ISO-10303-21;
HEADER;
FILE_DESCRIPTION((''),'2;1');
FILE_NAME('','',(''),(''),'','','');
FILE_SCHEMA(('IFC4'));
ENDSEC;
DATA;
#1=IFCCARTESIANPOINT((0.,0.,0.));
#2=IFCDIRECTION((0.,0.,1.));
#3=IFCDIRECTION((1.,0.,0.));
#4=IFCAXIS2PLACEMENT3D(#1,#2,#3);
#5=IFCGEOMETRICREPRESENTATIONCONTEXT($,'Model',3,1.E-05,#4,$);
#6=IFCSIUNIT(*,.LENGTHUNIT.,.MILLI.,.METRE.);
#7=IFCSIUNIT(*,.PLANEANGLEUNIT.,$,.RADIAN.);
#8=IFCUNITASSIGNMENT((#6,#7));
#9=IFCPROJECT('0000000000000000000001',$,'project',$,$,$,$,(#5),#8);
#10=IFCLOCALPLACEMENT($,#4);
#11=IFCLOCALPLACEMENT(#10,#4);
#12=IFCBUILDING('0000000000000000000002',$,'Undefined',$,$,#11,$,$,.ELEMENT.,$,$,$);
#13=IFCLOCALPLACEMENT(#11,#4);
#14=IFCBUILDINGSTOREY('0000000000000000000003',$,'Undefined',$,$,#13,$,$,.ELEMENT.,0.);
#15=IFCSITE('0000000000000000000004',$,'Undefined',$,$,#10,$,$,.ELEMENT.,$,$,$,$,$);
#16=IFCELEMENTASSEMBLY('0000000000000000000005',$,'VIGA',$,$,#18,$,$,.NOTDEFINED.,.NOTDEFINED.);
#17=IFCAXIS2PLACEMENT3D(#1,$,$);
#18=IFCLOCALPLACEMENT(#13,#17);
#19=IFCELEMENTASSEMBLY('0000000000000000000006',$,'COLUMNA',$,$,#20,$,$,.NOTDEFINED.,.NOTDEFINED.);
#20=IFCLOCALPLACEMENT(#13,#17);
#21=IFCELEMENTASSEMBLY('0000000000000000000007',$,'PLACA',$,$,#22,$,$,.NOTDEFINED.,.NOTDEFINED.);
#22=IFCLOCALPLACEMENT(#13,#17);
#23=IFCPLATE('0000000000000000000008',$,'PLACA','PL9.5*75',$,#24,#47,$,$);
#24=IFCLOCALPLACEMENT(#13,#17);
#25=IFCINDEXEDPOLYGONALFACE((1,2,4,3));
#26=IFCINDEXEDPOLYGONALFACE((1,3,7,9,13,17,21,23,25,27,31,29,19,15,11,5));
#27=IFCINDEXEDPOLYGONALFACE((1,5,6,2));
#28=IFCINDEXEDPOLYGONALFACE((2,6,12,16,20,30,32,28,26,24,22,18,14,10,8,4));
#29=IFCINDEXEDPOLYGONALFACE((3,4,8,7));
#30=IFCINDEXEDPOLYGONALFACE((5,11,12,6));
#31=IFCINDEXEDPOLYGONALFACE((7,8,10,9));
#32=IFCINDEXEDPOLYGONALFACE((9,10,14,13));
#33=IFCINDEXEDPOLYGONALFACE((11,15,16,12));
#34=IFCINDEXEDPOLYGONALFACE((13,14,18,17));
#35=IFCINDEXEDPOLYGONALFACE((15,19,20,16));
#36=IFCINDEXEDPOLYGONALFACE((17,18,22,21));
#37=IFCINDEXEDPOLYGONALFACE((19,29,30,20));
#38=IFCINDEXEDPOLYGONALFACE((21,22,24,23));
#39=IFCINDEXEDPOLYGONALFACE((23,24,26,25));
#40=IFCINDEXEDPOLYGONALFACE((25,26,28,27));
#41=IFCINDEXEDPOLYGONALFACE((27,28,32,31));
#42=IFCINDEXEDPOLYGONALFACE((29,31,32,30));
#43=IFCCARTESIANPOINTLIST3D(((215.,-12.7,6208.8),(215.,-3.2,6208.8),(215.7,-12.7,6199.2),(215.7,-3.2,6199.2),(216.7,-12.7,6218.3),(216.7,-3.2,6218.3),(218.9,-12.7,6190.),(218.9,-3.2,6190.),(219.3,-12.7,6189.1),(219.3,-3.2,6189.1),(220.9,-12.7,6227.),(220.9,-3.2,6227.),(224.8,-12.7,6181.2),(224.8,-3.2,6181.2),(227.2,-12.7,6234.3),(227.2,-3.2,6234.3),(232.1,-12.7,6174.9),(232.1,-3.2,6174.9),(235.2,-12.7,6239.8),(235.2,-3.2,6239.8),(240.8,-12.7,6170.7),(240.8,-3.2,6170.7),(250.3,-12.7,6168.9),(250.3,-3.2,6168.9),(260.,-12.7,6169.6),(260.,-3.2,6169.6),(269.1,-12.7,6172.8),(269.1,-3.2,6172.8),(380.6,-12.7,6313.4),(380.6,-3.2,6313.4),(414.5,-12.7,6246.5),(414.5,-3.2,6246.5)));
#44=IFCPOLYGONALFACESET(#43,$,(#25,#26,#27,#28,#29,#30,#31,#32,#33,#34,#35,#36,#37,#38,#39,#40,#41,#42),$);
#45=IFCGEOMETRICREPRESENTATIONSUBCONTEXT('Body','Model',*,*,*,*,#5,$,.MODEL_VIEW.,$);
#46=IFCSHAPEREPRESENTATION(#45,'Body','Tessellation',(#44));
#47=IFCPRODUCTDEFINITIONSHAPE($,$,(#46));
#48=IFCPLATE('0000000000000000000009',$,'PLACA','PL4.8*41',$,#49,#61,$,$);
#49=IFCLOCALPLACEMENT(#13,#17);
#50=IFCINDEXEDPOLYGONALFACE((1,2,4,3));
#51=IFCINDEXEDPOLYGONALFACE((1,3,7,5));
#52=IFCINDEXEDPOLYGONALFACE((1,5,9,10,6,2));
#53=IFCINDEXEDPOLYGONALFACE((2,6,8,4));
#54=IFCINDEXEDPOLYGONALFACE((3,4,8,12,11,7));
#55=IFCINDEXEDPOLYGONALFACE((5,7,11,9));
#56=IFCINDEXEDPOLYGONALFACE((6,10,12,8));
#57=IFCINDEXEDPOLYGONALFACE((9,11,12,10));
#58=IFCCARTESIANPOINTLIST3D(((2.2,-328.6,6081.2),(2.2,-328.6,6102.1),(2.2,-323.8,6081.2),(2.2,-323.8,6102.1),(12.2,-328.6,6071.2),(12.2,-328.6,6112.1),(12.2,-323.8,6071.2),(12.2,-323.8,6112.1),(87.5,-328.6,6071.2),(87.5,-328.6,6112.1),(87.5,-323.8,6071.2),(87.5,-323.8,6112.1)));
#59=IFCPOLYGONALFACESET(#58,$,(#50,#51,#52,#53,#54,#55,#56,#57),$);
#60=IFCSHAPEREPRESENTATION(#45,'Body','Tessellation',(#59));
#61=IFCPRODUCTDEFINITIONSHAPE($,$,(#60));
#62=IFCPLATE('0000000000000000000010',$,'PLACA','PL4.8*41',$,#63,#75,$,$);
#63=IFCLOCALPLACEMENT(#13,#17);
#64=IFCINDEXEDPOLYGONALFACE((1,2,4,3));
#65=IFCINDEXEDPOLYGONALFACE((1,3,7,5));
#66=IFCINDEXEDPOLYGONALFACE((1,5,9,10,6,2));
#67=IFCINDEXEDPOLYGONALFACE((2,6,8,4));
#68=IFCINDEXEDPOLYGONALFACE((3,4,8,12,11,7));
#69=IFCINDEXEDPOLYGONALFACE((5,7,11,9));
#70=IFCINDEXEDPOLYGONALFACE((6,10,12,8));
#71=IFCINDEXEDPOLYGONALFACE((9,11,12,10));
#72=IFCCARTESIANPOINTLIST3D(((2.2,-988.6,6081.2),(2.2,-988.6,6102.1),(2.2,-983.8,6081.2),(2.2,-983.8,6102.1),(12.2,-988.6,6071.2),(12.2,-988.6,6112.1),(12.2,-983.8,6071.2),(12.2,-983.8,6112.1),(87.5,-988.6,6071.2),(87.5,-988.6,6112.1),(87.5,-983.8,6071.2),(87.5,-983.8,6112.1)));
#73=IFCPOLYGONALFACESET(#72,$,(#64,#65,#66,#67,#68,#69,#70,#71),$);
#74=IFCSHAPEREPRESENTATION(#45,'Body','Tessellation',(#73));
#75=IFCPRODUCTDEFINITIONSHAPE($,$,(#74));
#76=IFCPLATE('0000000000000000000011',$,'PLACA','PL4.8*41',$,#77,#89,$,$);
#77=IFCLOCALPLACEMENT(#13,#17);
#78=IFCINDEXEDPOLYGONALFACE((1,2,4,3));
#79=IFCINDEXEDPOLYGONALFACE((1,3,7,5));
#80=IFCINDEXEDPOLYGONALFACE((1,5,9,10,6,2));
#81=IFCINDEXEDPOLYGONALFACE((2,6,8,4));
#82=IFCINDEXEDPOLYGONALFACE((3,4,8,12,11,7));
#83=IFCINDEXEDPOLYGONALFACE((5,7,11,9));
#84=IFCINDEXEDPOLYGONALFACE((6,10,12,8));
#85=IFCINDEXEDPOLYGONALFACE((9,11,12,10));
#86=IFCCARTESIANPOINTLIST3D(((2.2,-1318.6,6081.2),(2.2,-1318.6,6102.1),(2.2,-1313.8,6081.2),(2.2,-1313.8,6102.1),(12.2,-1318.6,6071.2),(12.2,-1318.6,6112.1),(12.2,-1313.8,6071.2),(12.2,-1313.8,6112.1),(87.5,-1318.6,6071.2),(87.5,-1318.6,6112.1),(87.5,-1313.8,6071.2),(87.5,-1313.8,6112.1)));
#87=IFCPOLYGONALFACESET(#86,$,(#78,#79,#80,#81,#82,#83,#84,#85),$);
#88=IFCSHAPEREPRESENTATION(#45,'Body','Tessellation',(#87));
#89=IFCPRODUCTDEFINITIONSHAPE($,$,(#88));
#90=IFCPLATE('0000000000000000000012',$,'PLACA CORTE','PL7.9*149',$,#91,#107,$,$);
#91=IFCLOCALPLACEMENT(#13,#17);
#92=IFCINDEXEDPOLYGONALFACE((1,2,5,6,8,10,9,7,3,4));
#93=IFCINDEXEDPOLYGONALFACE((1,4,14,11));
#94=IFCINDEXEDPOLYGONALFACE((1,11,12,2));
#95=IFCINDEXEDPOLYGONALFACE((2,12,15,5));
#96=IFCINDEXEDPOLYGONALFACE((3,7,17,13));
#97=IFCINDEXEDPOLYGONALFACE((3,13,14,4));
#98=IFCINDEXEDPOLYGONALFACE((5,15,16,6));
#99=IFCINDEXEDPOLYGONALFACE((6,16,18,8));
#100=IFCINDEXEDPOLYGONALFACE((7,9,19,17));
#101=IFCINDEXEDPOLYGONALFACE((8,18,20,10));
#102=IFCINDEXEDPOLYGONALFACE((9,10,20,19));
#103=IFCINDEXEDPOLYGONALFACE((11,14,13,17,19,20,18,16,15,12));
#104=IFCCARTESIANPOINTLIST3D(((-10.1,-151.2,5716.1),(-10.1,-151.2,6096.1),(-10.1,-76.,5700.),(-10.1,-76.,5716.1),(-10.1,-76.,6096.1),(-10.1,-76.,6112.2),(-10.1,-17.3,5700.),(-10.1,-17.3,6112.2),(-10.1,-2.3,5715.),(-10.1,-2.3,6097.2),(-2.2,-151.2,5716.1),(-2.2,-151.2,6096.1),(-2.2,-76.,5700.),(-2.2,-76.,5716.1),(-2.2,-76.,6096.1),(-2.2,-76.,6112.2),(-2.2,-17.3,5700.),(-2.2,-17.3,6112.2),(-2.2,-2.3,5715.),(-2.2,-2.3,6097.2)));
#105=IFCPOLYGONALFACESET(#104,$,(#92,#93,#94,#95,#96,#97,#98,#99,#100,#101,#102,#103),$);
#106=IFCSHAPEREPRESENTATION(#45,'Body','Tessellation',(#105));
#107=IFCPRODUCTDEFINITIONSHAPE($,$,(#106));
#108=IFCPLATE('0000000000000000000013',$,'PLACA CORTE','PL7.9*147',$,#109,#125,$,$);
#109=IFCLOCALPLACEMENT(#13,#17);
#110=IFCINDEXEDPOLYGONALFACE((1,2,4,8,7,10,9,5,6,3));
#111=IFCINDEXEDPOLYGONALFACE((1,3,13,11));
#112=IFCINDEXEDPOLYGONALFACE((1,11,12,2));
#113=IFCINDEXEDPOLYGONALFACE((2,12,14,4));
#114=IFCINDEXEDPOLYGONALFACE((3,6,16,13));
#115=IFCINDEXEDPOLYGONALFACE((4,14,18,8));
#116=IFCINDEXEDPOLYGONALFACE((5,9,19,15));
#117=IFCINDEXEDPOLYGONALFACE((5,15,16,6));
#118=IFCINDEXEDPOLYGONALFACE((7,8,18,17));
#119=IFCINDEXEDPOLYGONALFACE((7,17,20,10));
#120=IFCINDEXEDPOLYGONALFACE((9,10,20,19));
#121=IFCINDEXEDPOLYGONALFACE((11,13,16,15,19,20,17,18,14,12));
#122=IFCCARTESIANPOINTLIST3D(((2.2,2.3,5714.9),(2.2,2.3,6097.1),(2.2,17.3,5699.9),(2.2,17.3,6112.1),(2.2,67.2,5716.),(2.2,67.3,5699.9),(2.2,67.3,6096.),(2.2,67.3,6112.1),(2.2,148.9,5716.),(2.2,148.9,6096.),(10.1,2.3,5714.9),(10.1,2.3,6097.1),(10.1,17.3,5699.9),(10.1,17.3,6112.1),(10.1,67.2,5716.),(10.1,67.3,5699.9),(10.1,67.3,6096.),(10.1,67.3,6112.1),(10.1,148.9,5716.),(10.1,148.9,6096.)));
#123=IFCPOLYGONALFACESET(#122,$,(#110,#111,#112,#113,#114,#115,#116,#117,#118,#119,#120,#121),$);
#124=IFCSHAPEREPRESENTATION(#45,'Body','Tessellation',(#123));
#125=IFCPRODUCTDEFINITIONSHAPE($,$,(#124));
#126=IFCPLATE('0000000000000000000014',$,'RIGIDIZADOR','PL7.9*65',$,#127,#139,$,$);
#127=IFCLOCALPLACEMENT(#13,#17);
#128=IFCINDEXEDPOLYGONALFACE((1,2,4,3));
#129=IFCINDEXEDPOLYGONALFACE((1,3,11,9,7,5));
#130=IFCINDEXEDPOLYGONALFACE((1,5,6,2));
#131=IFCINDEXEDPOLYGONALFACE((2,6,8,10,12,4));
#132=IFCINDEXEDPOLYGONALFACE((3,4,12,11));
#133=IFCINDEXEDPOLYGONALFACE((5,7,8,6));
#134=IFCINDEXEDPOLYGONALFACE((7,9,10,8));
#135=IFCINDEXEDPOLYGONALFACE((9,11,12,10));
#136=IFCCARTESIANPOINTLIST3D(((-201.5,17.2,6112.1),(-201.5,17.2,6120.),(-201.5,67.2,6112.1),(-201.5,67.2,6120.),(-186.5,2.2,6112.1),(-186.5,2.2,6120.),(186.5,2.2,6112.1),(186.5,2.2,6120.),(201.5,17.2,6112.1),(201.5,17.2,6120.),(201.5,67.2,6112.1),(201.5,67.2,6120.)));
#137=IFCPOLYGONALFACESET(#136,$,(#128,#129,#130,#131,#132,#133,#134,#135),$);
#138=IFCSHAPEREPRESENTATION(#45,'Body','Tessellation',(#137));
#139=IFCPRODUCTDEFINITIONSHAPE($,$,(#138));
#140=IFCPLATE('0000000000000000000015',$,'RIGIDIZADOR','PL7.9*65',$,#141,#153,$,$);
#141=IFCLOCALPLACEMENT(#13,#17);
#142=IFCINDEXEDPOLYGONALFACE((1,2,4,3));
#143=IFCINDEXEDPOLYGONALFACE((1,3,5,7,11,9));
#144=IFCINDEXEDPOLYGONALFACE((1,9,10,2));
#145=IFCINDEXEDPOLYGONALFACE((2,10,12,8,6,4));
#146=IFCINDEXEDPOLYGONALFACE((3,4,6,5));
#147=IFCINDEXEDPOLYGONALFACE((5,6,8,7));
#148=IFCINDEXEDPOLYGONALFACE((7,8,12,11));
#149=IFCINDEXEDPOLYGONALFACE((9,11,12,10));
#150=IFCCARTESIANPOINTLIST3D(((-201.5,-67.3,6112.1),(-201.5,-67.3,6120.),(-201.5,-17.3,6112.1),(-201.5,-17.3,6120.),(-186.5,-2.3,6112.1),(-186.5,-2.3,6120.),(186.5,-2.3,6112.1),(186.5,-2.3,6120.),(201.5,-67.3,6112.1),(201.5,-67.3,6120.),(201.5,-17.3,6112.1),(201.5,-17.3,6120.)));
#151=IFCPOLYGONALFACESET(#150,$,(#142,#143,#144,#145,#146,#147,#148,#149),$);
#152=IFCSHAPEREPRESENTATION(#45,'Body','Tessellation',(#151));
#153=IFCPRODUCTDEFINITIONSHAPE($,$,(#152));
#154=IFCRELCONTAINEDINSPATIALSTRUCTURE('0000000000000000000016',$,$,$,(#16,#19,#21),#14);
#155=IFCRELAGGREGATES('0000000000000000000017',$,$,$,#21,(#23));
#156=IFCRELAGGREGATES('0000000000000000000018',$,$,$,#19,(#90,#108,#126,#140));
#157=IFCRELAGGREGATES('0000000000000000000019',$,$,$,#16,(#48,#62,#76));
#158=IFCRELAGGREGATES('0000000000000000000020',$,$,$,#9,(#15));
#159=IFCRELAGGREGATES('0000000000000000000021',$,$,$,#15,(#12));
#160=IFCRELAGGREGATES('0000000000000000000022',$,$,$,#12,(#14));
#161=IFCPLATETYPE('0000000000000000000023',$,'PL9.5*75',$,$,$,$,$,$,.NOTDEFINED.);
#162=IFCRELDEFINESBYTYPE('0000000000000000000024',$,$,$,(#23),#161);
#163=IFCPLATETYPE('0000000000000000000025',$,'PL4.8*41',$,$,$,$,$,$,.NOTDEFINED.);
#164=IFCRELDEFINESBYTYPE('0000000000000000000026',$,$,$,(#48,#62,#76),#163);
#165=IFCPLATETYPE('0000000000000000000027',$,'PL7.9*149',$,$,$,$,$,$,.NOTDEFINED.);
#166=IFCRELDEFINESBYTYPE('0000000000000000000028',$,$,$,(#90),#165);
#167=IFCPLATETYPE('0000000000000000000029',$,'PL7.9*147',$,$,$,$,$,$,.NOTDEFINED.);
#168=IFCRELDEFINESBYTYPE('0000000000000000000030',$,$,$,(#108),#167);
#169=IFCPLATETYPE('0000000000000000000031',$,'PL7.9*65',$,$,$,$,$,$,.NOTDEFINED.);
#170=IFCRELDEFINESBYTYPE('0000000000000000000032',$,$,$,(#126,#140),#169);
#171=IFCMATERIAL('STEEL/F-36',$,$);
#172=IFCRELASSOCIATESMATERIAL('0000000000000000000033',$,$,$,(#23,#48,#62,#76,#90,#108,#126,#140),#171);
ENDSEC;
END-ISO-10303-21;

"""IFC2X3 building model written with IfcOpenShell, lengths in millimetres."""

from ifc_helpers import new_model, si_unit, frame, frame_2d, origin_with_axes, place, context, subcontext, project, spatial, polyline, circle_curve, parameter, trimmed, segment, composite_curve, outline, extrude, material, type_object, element, aggregate, save


model = new_model("IFC2X3")

# Units and contexts
model_context = context("Model", 3, precision=1e-05, world=origin_with_axes())
body_context = subcontext(model_context, "Body", "Model", "MODEL_VIEW")
ifc_project = project(units=[si_unit("LENGTHUNIT", "METRE", prefix="MILLI"), si_unit("PLANEANGLEUNIT", "RADIAN")], contexts=[model_context])

# Site, building, storey
site_placement = place(None, origin_with_axes())
site = spatial("IfcSite", under=ifc_project, at=site_placement, Name="Undefined", CompositionType="ELEMENT")
building_placement = place(site_placement, origin_with_axes())
building = spatial("IfcBuilding", under=site, at=building_placement, Name="Undefined", CompositionType="ELEMENT")
storey_placement = place(building_placement, origin_with_axes())
storey = spatial("IfcBuildingStorey", under=building, at=storey_placement, Name="Undefined", CompositionType="ELEMENT", Elevation=0.0)

# Element assembly
assembly_1_placement = place(storey_placement, origin_with_axes())
assembly_1 = element("IfcElementAssembly", 1, at=assembly_1_placement, inside=storey, Name="VIGA", AssemblyPlace="NOTDEFINED", PredefinedType="NOTDEFINED")
ifc_material_1 = material(Name="STEEL/F-36")

# Element assembly
assembly_2_placement = place(storey_placement, origin_with_axes())
assembly_2 = element("IfcElementAssembly", 2, at=assembly_2_placement, inside=storey, Name="COLUMNA", AssemblyPlace="NOTDEFINED", PredefinedType="NOTDEFINED")

# Element assembly, plate
assembly_3_placement = place(storey_placement, origin_with_axes())
assembly_3 = element("IfcElementAssembly", 3, at=assembly_3_placement, inside=storey, Name="PLACA", AssemblyPlace="NOTDEFINED", PredefinedType="NOTDEFINED")
plate_type_1 = type_object("IfcPlateType", Name="PL9.5*75", PredefinedType="NOTDEFINED")
plate_1_placement = place(assembly_3_placement, frame((202.2, -7.9, 6223.0), z_axis=(0.0, -1.0, 0.0), x_axis=(0.451662, 0.0, -0.892189)))
plate_1 = element("IfcPlate", 4, at=plate_1_placement, type_object=plate_type_1, material=ifc_material_1, Name="PLACA", Description="PL9.5*75", context=body_context, shape_type="SweptSolid", body=[
    extrude(outline(composite_curve([segment(trimmed(circle_curve(frame_2d((37.0, 37.0), x_axis=(-1.0, 0.0)), 37.0), [parameter(0.0)], [parameter(1.570796)], True, "PARAMETER"), True, "CONTINUOUS"), segment(polyline([(37.0, 0.0), (38.0, 0.0)]), True, "CONTINUOUS"), segment(trimmed(circle_curve(frame_2d((38.0, 37.0), x_axis=(0.0, -1.0)), 37.0), [parameter(0.0)], [parameter(1.570797)], True, "PARAMETER"), True, "CONTINUOUS"), segment(polyline([(75.0, 37.0), (75.0, 200.0), (0.0, 200.0), (0.0, 37.0)]), True, "CONTINUOUS")], self_intersect=True)), frame((0.0, 0.0, -4.8), z_axis=(0.0, 0.0, 1.0), x_axis=(1.0, 0.0, 0.0)), (0.0, 0.0, 1.0), 9.5),
])
aggregate(assembly_3, [plate_1])

# Plates
plate_type_2 = type_object("IfcPlateType", Name="PL4.8*41", PredefinedType="NOTDEFINED")
plate_2_placement = place(assembly_1_placement, frame((2.2, -326.2, 6112.1), z_axis=(0.0, 1.0, 0.0), x_axis=(1.0, 0.0, -0.000007)))
plate_2 = element("IfcPlate", 5, at=plate_2_placement, type_object=plate_type_2, material=ifc_material_1, Name="PLACA", Description="PL4.8*41", context=body_context, shape_type="SweptSolid", body=[
    extrude(outline(polyline([(0.0, 10.0), (10.0, 0.0), (85.2, 0.0), (85.3, 40.9), (10.0, 40.9), (0.0, 30.9), (0.0, 10.0)])), frame((0.0, 0.0, -2.4), z_axis=(0.0, 0.0, 1.0), x_axis=(1.0, 0.0, 0.0)), (0.0, 0.0, 1.0), 4.8),
])
plate_3_placement = place(assembly_1_placement, frame((2.2, -986.2, 6112.1), z_axis=(0.0, 1.0, 0.0), x_axis=(1.0, 0.0, -0.000007)))
plate_3 = element("IfcPlate", 6, at=plate_3_placement, type_object=plate_type_2, material=ifc_material_1, Name="PLACA", Description="PL4.8*41", context=body_context, shape_type="SweptSolid", body=[
    extrude(outline(polyline([(0.0, 10.0), (10.0, 0.0), (85.2, 0.0), (85.3, 40.9), (10.0, 40.9), (0.0, 30.9), (0.0, 10.0)])), frame((0.0, 0.0, -2.4), z_axis=(0.0, 0.0, 1.0), x_axis=(1.0, 0.0, 0.0)), (0.0, 0.0, 1.0), 4.8),
])
plate_4_placement = place(assembly_1_placement, frame((2.2, -1316.2, 6112.1), z_axis=(0.0, 1.0, 0.0), x_axis=(1.0, 0.0, -0.000007)))
plate_4 = element("IfcPlate", 7, at=plate_4_placement, type_object=plate_type_2, material=ifc_material_1, Name="PLACA", Description="PL4.8*41", context=body_context, shape_type="SweptSolid", body=[
    extrude(outline(polyline([(0.0, 10.0), (10.0, 0.0), (85.2, 0.0), (85.3, 40.9), (10.0, 40.9), (0.0, 30.9), (0.0, 10.0)])), frame((0.0, 0.0, -2.4), z_axis=(0.0, 0.0, 1.0), x_axis=(1.0, 0.0, 0.0)), (0.0, 0.0, 1.0), 4.8),
])
plate_type_3 = type_object("IfcPlateType", Name="PL7.9*149", PredefinedType="NOTDEFINED")
plate_5_placement = place(assembly_2_placement, frame((-6.2, -2.3, 6112.2), z_axis=(1.0, 0.0, 0.0), x_axis=(0.0, -1.0, 0.0)))
plate_5 = element("IfcPlate", 8, at=plate_5_placement, type_object=plate_type_3, material=ifc_material_1, Name="PLACA CORTE", Description="PL7.9*149", context=body_context, shape_type="SweptSolid", body=[
    extrude(outline(polyline([(0.0, 15.0), (15.0, 0.0), (73.8, 0.0), (73.7, 16.1), (148.9, 16.1), (148.9, 396.1), (73.7, 396.1), (73.7, 412.2), (15.0, 412.2), (0.0, 397.2), (0.0, 15.0)])), frame((0.0, 0.0, -4.0), z_axis=(0.0, 0.0, 1.0), x_axis=(1.0, 0.0, 0.0)), (0.0, 0.0, 1.0), 7.9),
])
plate_type_4 = type_object("IfcPlateType", Name="PL7.9*147", PredefinedType="NOTDEFINED")
plate_6_placement = place(assembly_2_placement, frame((6.2, 2.3, 6112.1), z_axis=(-1.0, 0.0, 0.0), x_axis=(0.0, 1.0, 0.0)))
plate_6 = element("IfcPlate", 9, at=plate_6_placement, type_object=plate_type_4, material=ifc_material_1, Name="PLACA CORTE", Description="PL7.9*147", context=body_context, shape_type="SweptSolid", body=[
    extrude(outline(polyline([(0.0, 15.0), (15.0, 0.0), (65.0, 0.0), (65.0, 16.1), (146.6, 16.1), (146.6, 396.1), (65.0, 396.1), (65.0, 412.2), (15.0, 412.2), (0.0, 397.2), (0.0, 15.0)])), frame((0.0, 0.0, -4.0), z_axis=(0.0, 0.0, 1.0), x_axis=(1.0, 0.0, 0.0)), (0.0, 0.0, 1.0), 7.9),
])
plate_type_5 = type_object("IfcPlateType", Name="PL7.9*65", PredefinedType="NOTDEFINED")
plate_7_placement = place(assembly_2_placement, frame((201.5, 2.2, 6116.0), z_axis=(0.0, 0.0, 1.0), x_axis=(0.000001, 1.0, 0.0)))
plate_7 = element("IfcPlate", 10, at=plate_7_placement, type_object=plate_type_5, material=ifc_material_1, Name="RIGIDIZADOR", Description="PL7.9*65", context=body_context, shape_type="SweptSolid", body=[
    extrude(outline(polyline([(0.0, 15.0), (15.0, 0.0), (65.0, 0.0), (65.0, 403.0), (15.0, 403.0), (0.0, 388.0), (0.0, 15.0)])), frame((0.0, 0.0, -4.0), z_axis=(0.0, 0.0, 1.0), x_axis=(1.0, 0.0, 0.0)), (0.0, 0.0, 1.0), 7.9),
])
plate_8_placement = place(assembly_2_placement, frame((201.5, -2.3, 6116.0), z_axis=(0.0, 0.0, -1.0), x_axis=(-0.000001, -1.0, 0.0)))
plate_8 = element("IfcPlate", 11, at=plate_8_placement, type_object=plate_type_5, material=ifc_material_1, Name="RIGIDIZADOR", Description="PL7.9*65", context=body_context, shape_type="SweptSolid", body=[
    extrude(outline(polyline([(0.0, 15.0), (15.0, 0.0), (65.0, 0.0), (65.0, 403.0), (15.0, 403.0), (0.0, 388.0), (0.0, 15.0)])), frame((0.0, 0.0, -4.0), z_axis=(0.0, 0.0, 1.0), x_axis=(1.0, 0.0, 0.0)), (0.0, 0.0, 1.0), 7.9),
])

aggregate(assembly_2, [plate_5, plate_6, plate_7, plate_8])

aggregate(assembly_1, [plate_2, plate_3, plate_4])

save(model, "model.ifc")
